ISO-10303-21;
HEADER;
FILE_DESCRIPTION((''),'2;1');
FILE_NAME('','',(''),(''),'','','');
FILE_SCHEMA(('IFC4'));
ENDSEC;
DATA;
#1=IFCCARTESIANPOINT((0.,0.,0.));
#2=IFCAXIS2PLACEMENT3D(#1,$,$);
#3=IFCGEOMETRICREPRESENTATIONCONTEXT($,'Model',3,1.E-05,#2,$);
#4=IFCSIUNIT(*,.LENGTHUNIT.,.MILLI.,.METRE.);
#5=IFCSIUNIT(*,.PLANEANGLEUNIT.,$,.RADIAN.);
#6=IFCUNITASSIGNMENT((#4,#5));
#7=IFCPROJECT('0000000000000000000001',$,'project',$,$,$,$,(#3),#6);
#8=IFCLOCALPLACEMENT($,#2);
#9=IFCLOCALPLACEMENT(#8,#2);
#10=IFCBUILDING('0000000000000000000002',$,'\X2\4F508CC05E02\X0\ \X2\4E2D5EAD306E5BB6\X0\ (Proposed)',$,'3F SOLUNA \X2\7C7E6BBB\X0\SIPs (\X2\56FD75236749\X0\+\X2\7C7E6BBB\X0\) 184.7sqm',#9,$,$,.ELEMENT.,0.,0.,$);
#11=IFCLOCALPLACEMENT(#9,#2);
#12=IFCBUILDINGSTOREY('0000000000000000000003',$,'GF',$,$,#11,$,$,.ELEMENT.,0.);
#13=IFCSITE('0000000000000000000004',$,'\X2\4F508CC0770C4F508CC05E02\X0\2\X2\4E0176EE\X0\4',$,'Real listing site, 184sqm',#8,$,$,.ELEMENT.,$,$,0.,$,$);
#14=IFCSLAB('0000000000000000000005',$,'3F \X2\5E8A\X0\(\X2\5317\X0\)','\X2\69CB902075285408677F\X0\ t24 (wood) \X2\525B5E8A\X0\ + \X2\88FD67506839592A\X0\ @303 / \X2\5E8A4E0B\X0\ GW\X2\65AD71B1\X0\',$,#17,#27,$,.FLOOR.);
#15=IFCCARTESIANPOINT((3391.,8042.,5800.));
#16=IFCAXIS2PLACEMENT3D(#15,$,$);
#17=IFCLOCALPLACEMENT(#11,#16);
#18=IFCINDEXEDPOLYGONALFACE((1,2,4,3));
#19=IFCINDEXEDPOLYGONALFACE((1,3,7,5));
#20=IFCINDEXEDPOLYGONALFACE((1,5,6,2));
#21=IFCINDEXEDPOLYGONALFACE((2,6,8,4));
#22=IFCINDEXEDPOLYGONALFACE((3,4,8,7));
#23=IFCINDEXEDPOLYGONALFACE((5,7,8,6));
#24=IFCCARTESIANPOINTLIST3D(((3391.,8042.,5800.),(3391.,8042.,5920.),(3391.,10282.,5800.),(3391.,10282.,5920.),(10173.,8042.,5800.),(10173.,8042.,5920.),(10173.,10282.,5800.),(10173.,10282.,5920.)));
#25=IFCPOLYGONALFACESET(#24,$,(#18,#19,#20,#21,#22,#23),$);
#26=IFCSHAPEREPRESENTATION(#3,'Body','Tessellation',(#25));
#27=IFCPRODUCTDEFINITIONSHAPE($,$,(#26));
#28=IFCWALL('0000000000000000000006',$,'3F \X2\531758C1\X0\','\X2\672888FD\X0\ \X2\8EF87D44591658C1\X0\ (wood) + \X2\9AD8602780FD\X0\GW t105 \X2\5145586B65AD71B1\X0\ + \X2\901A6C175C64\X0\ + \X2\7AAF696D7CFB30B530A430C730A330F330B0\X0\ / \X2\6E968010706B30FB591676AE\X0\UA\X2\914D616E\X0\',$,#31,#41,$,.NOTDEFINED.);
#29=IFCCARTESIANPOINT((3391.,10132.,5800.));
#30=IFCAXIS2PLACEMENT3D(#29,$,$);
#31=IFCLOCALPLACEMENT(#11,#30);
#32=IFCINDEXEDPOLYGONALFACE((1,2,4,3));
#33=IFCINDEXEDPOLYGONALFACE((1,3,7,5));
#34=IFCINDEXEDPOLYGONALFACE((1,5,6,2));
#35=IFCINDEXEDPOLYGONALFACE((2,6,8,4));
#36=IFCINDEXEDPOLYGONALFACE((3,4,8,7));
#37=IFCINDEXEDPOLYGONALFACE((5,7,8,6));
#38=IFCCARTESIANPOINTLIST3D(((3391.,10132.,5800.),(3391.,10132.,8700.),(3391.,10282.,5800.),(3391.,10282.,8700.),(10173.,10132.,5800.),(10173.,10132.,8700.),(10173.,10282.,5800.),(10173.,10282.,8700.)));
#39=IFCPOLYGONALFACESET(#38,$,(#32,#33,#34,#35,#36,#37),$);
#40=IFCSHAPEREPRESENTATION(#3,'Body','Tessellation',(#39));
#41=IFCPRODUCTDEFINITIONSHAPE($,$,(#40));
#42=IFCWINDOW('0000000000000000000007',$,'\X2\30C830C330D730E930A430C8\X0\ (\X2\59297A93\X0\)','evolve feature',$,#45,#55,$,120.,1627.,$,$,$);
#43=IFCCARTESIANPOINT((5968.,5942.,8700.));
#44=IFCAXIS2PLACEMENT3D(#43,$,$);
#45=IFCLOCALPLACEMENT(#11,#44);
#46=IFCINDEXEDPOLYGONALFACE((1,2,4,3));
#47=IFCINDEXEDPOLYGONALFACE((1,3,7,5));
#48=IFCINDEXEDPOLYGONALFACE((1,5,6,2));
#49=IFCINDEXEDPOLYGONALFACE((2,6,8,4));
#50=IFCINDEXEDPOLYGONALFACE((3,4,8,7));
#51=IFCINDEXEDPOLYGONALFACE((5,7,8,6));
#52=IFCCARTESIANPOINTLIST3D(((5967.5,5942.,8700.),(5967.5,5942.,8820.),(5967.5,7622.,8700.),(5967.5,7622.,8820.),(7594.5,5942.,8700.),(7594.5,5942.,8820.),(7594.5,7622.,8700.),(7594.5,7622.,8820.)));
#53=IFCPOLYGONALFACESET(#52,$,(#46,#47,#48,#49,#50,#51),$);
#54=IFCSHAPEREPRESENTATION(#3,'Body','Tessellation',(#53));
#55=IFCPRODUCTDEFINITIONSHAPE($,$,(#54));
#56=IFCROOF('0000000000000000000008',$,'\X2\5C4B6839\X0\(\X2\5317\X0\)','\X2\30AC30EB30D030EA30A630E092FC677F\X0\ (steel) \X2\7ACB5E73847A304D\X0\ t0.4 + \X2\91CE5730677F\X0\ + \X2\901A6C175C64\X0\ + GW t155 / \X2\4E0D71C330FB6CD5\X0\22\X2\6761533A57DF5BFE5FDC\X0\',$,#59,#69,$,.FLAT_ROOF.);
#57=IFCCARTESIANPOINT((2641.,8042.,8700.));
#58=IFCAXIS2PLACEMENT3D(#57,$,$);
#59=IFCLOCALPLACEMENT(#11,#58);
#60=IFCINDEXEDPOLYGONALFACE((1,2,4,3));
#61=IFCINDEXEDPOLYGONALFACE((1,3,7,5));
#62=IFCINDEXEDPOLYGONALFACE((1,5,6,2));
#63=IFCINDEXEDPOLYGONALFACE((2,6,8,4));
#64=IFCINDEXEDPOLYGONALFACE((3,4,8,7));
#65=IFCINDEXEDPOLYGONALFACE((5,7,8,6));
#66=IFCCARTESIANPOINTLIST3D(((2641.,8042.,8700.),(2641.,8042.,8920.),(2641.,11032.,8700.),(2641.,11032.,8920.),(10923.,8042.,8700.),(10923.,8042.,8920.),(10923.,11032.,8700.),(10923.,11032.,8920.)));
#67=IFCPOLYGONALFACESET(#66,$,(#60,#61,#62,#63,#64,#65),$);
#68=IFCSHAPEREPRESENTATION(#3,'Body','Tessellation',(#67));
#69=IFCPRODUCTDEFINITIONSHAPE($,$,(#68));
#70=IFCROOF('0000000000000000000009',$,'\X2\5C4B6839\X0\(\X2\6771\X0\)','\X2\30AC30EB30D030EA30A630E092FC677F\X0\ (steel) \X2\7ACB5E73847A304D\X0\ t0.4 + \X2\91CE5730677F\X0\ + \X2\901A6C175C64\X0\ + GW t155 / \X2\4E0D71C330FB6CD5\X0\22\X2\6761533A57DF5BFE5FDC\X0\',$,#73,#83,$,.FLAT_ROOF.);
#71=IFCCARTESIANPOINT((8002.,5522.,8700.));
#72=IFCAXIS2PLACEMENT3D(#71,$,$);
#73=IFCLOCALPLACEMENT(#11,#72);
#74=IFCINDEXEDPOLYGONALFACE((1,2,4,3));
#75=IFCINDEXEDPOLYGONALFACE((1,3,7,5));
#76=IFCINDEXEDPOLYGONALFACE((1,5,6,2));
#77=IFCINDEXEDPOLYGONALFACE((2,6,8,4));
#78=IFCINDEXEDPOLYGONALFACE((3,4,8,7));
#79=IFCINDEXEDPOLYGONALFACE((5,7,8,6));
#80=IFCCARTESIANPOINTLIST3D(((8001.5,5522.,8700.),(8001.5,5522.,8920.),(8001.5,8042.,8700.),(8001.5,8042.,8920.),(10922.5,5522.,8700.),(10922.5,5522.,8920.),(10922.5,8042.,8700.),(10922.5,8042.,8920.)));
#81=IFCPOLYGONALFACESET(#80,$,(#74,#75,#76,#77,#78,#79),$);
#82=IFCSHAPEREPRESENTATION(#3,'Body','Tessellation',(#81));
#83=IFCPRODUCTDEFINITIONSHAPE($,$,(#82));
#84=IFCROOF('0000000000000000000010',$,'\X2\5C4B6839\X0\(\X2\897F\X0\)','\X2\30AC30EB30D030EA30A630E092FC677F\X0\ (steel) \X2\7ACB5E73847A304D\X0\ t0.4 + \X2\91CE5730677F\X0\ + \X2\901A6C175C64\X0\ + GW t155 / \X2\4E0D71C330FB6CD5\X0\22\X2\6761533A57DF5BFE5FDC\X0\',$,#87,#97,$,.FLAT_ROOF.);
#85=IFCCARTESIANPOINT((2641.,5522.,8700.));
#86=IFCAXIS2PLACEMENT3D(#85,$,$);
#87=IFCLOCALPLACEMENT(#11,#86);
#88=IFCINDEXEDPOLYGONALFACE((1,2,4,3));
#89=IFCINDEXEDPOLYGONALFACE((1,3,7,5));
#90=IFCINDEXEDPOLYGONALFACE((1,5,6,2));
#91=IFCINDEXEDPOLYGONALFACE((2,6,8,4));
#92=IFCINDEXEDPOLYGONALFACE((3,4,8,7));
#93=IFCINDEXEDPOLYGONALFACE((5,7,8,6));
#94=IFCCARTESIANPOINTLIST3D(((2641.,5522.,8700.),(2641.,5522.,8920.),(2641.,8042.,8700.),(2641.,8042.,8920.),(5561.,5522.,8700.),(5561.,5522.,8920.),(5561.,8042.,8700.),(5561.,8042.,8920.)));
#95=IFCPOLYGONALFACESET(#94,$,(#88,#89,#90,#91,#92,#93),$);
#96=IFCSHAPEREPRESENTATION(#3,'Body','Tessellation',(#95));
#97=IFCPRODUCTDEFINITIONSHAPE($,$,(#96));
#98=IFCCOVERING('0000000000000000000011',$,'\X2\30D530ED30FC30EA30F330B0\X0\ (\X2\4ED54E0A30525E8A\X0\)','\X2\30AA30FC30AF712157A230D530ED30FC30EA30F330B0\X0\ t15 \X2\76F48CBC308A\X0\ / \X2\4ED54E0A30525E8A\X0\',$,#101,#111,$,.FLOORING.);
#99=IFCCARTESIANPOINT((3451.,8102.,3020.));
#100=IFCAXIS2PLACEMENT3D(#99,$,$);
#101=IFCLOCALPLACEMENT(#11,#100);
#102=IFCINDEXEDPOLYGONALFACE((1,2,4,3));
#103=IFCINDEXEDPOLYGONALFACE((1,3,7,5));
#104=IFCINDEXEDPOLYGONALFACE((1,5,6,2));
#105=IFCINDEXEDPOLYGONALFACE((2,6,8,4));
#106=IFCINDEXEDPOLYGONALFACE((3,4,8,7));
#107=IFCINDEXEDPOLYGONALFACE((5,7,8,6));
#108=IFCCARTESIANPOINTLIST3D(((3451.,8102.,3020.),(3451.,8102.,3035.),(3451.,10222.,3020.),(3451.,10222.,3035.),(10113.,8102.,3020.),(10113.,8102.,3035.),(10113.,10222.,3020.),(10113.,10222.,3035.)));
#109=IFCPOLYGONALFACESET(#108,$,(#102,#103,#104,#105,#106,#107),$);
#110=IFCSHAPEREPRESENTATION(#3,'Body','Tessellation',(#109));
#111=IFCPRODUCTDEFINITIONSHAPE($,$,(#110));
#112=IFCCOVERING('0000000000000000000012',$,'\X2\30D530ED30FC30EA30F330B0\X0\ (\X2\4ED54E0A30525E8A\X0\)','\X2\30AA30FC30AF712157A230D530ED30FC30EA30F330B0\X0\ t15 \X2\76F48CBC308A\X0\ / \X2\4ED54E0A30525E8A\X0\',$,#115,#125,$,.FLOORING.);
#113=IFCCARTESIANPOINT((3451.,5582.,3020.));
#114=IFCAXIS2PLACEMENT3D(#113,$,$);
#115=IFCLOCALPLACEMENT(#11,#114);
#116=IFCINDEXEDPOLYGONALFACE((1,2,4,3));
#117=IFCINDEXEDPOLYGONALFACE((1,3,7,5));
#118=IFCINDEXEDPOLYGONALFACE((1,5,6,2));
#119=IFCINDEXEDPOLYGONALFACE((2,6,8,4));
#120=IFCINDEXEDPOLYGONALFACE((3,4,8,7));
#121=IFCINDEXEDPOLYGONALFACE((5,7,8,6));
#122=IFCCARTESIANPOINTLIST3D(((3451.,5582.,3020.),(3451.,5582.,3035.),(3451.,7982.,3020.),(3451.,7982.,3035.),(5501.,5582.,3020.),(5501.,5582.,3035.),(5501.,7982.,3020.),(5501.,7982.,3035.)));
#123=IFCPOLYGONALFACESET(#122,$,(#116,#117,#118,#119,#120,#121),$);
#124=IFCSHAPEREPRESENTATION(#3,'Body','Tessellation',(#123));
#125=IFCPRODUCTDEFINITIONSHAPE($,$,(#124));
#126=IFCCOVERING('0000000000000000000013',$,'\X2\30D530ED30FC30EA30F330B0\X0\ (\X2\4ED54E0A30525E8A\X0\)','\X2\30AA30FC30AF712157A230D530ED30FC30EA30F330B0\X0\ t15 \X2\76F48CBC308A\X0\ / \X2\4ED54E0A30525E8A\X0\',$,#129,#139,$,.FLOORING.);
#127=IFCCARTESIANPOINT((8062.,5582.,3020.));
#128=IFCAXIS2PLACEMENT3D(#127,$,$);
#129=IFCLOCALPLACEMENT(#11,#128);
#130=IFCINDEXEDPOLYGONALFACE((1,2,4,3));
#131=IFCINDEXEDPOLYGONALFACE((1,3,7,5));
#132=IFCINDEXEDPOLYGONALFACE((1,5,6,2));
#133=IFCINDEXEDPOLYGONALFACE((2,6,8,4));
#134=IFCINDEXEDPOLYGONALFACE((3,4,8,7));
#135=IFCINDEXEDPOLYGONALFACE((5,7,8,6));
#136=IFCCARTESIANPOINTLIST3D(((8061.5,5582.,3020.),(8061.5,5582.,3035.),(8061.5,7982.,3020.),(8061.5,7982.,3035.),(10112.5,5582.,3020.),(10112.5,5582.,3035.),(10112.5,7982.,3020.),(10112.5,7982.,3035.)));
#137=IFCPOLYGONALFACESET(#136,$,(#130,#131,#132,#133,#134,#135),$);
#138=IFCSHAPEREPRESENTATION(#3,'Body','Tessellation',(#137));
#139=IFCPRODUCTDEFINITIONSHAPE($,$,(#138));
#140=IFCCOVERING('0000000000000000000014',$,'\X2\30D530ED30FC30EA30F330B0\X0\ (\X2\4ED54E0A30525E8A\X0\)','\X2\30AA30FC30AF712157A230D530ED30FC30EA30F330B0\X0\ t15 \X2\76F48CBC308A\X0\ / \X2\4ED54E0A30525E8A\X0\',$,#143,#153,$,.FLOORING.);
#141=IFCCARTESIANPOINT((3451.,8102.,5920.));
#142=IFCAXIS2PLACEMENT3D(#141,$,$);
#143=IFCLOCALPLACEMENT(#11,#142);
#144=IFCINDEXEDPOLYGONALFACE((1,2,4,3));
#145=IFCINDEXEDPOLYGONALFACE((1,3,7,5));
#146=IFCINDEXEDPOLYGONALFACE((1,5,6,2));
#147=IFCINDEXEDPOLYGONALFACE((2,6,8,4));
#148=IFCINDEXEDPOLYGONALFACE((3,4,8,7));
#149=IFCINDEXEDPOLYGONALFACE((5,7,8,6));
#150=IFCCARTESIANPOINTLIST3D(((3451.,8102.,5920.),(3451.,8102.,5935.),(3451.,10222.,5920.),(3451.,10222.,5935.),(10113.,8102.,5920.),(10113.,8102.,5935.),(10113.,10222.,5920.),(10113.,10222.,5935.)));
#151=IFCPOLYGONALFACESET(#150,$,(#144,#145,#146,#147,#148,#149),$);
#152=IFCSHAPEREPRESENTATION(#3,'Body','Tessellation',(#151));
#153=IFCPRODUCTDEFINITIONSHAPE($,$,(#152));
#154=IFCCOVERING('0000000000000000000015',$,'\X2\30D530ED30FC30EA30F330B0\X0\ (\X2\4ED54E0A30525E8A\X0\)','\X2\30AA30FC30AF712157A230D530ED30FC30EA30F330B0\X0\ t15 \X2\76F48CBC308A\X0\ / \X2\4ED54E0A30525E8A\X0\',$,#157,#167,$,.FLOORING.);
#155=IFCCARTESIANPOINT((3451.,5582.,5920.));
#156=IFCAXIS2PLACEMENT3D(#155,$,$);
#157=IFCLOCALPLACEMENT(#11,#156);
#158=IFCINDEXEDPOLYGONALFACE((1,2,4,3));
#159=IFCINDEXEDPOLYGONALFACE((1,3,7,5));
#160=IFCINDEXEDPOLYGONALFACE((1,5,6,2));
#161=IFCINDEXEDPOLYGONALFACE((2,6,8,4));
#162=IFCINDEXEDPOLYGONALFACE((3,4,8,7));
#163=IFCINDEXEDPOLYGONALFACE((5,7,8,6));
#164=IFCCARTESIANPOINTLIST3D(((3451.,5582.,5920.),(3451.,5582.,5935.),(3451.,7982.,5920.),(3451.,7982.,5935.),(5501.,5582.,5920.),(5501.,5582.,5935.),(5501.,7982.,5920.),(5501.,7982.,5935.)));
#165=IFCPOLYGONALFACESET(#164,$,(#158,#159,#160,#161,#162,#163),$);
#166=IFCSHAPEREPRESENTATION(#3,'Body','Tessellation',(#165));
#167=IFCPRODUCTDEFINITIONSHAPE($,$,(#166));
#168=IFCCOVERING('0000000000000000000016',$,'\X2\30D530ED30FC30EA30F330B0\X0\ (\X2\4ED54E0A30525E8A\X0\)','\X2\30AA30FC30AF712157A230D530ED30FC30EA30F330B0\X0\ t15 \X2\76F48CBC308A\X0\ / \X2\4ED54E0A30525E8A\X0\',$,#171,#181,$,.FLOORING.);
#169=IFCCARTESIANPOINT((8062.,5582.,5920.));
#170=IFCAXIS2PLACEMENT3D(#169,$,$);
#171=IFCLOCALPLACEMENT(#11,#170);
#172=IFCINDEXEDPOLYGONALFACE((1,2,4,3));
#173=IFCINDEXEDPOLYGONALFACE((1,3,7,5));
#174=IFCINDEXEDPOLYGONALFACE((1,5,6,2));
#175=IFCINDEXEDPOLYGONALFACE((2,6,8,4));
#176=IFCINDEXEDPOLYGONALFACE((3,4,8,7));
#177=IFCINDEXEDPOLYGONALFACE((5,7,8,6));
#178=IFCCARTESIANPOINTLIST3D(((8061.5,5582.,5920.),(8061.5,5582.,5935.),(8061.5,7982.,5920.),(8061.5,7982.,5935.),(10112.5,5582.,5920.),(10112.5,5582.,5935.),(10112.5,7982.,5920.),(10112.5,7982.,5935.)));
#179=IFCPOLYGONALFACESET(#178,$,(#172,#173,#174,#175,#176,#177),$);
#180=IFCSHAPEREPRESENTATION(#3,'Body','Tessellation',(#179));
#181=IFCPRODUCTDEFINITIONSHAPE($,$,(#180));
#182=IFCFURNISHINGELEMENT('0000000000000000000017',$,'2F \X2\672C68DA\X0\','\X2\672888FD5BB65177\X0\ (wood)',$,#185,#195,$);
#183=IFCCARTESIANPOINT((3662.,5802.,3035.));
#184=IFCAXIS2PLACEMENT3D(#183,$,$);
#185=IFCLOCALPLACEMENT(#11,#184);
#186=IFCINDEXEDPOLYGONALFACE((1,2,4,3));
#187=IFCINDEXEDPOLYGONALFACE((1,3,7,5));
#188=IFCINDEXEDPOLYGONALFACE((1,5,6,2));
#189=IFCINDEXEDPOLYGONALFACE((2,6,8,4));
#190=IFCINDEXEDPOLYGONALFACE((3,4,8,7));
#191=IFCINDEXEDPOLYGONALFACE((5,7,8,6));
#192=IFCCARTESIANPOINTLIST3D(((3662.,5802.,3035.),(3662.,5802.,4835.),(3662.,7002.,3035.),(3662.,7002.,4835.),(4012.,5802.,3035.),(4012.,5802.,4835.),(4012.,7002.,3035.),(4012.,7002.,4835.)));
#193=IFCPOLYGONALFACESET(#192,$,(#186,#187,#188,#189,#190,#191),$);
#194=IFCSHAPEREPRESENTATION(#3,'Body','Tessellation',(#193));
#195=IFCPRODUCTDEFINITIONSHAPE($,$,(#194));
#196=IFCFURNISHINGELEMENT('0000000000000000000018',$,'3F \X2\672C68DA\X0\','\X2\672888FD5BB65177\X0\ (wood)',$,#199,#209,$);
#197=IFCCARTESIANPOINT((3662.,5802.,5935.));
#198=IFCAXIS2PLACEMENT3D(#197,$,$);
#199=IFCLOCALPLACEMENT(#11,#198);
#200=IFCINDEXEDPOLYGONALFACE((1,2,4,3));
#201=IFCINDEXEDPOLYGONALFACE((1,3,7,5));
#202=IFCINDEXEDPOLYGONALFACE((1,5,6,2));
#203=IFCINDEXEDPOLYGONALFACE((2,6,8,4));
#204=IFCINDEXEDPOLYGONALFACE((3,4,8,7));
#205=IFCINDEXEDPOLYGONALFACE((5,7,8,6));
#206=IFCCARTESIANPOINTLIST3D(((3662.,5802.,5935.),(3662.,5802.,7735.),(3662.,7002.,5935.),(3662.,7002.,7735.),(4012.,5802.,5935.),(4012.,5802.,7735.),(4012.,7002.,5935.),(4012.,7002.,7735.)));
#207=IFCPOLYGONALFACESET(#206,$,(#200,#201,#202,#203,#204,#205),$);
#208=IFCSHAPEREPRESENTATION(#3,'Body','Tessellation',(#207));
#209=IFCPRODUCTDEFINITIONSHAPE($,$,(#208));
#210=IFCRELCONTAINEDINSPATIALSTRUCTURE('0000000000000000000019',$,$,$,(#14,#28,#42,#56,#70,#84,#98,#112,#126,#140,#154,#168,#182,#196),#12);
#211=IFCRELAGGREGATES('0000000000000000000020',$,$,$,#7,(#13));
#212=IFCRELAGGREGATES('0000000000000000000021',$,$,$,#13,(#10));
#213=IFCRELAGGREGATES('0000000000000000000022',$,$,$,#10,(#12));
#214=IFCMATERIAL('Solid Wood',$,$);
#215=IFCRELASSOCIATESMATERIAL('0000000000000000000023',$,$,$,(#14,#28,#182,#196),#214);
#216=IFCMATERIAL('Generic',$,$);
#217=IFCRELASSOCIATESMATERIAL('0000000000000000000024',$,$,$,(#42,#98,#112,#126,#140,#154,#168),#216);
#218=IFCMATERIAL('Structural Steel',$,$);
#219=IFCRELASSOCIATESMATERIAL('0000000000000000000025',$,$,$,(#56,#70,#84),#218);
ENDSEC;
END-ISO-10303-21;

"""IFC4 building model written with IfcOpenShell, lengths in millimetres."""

from ifc_helpers import new_model, si_unit, frame, frame_2d, origin, place, context, project, spatial, rectangle, extrude, material, element, save


model = new_model("IFC4")

# Units and contexts
model_context = context("Model", 3, precision=1e-05, world=origin())
ifc_project = project(units=[si_unit("LENGTHUNIT", "METRE", prefix="MILLI"), si_unit("PLANEANGLEUNIT", "RADIAN")], contexts=[model_context])

# Site, building, storey
site_placement = place(None, origin())
site = spatial("IfcSite", under=ifc_project, at=site_placement, Name="佐賀県佐賀市2丁目4", ObjectType="Real listing site, 184sqm", CompositionType="ELEMENT", RefElevation=0.0)
building_placement = place(site_placement, origin())
building = spatial("IfcBuilding", under=site, at=building_placement, Name="佐賀市 中庭の家 (Proposed)", ObjectType="3F SOLUNA 籾殻SIPs (国産杉+籾殻) 184.7sqm", CompositionType="ELEMENT", ElevationOfRefHeight=0.0, ElevationOfTerrain=0.0)
storey_placement = place(building_placement, origin())
storey = spatial("IfcBuildingStorey", under=building, at=storey_placement, Name="GF", CompositionType="ELEMENT", Elevation=0.0)

# Slab
ifc_material_1 = material(Name="Solid Wood")
slab_placement = place(storey_placement, frame((3391.0, 8042.0, 5800.0)))
element("IfcSlab", 1, at=slab_placement, inside=storey, material=ifc_material_1, Name="3F 床(北)", Description="構造用合板 t24 (wood) 剛床 + 製材根太 @303 / 床下 GW断熱", PredefinedType="FLOOR", context=model_context, shape_type="SweptSolid", body=[
    extrude(rectangle(XDim=6782.0, YDim=2240.0, at=frame_2d((3391.0, 1120.0))), frame((3391.0, 8042.0, 5800.0)), (0.0, 0.0, 1.0), 120.0),
])

# Wall
wall_1_placement = place(storey_placement, frame((3391.0, 10132.0, 5800.0)))
element("IfcWall", 2, at=wall_1_placement, inside=storey, material=ifc_material_1, Name="3F 北壁", Description="木製 軸組外壁 (wood) + 高性能GW t105 充填断熱 + 通気層 + 窯業系サイディング / 準耐火・外皮UA配慮", PredefinedType="NOTDEFINED", context=model_context, shape_type="SweptSolid", body=[
    extrude(rectangle(XDim=6782.0, YDim=150.0, at=frame_2d((3391.0, 75.0))), frame((3391.0, 10132.0, 5800.0)), (0.0, 0.0, 1.0), 2900.0),
])

# Window
ifc_material_2 = material(Name="Generic")
window_1_placement = place(storey_placement, frame((5968.0, 5942.0, 8700.0)))
element("IfcWindow", 3, at=window_1_placement, inside=storey, material=ifc_material_2, Name="トップライト (天窓)", Description="evolve feature", OverallHeight=120.0, OverallWidth=1627.0, context=model_context, shape_type="SweptSolid", body=[
    extrude(rectangle(XDim=1627.0, YDim=1680.0, at=frame_2d((813.0, 840.0))), frame((5968.0, 5942.0, 8700.0)), (0.0, 0.0, 1.0), 120.0),
])

# Roofs
ifc_material_3 = material(Name="Structural Steel")
roof_1_placement = place(storey_placement, frame((2641.0, 8042.0, 8700.0)))
element("IfcRoof", 4, at=roof_1_placement, inside=storey, material=ifc_material_3, Name="屋根(北)", Description="ガルバリウム鋼板 (steel) 立平葺き t0.4 + 野地板 + 通気層 + GW t155 / 不燃・法22条区域対応", PredefinedType="FLAT_ROOF", context=model_context, shape_type="SweptSolid", body=[
    extrude(rectangle(XDim=8282.0, YDim=2990.0, at=frame_2d((4141.0, 1495.0))), frame((2641.0, 8042.0, 8700.0)), (0.0, 0.0, 1.0), 220.0),
])
roof_2_placement = place(storey_placement, frame((8002.0, 5522.0, 8700.0)))
element("IfcRoof", 5, at=roof_2_placement, inside=storey, material=ifc_material_3, Name="屋根(東)", Description="ガルバリウム鋼板 (steel) 立平葺き t0.4 + 野地板 + 通気層 + GW t155 / 不燃・法22条区域対応", PredefinedType="FLAT_ROOF", context=model_context, shape_type="SweptSolid", body=[
    extrude(rectangle(XDim=2921.0, YDim=2520.0, at=frame_2d((1460.0, 1260.0))), frame((8002.0, 5522.0, 8700.0)), (0.0, 0.0, 1.0), 220.0),
])
roof_3_placement = place(storey_placement, frame((2641.0, 5522.0, 8700.0)))
element("IfcRoof", 6, at=roof_3_placement, inside=storey, material=ifc_material_3, Name="屋根(西)", Description="ガルバリウム鋼板 (steel) 立平葺き t0.4 + 野地板 + 通気層 + GW t155 / 不燃・法22条区域対応", PredefinedType="FLAT_ROOF", context=model_context, shape_type="SweptSolid", body=[
    extrude(rectangle(XDim=2920.0, YDim=2520.0, at=frame_2d((1460.0, 1260.0))), frame((2641.0, 5522.0, 8700.0)), (0.0, 0.0, 1.0), 220.0),
])

# Coverings
covering_1_placement = place(storey_placement, frame((3451.0, 8102.0, 3020.0)))
element("IfcCovering", 7, at=covering_1_placement, inside=storey, material=ifc_material_2, Name="フローリング (仕上げ床)", Description="オーク無垢フローリング t15 直貼り / 仕上げ床", PredefinedType="FLOORING", context=model_context, shape_type="SweptSolid", body=[
    extrude(rectangle(XDim=6662.0, YDim=2120.0, at=frame_2d((3331.0, 1060.0))), frame((3451.0, 8102.0, 3020.0)), (0.0, 0.0, 1.0), 15.0),
])
covering_2_placement = place(storey_placement, frame((3451.0, 5582.0, 3020.0)))
element("IfcCovering", 8, at=covering_2_placement, inside=storey, material=ifc_material_2, Name="フローリング (仕上げ床)", Description="オーク無垢フローリング t15 直貼り / 仕上げ床", PredefinedType="FLOORING", context=model_context, shape_type="SweptSolid", body=[
    extrude(rectangle(XDim=2050.0, YDim=2400.0, at=frame_2d((1025.0, 1200.0))), frame((3451.0, 5582.0, 3020.0)), (0.0, 0.0, 1.0), 15.0),
])
covering_3_placement = place(storey_placement, frame((8062.0, 5582.0, 3020.0)))
element("IfcCovering", 9, at=covering_3_placement, inside=storey, material=ifc_material_2, Name="フローリング (仕上げ床)", Description="オーク無垢フローリング t15 直貼り / 仕上げ床", PredefinedType="FLOORING", context=model_context, shape_type="SweptSolid", body=[
    extrude(rectangle(XDim=2051.0, YDim=2400.0, at=frame_2d((1025.0, 1200.0))), frame((8062.0, 5582.0, 3020.0)), (0.0, 0.0, 1.0), 15.0),
])
covering_4_placement = place(storey_placement, frame((3451.0, 8102.0, 5920.0)))
element("IfcCovering", 10, at=covering_4_placement, inside=storey, material=ifc_material_2, Name="フローリング (仕上げ床)", Description="オーク無垢フローリング t15 直貼り / 仕上げ床", PredefinedType="FLOORING", context=model_context, shape_type="SweptSolid", body=[
    extrude(rectangle(XDim=6662.0, YDim=2120.0, at=frame_2d((3331.0, 1060.0))), frame((3451.0, 8102.0, 5920.0)), (0.0, 0.0, 1.0), 15.0),
])
covering_5_placement = place(storey_placement, frame((3451.0, 5582.0, 5920.0)))
element("IfcCovering", 11, at=covering_5_placement, inside=storey, material=ifc_material_2, Name="フローリング (仕上げ床)", Description="オーク無垢フローリング t15 直貼り / 仕上げ床", PredefinedType="FLOORING", context=model_context, shape_type="SweptSolid", body=[
    extrude(rectangle(XDim=2050.0, YDim=2400.0, at=frame_2d((1025.0, 1200.0))), frame((3451.0, 5582.0, 5920.0)), (0.0, 0.0, 1.0), 15.0),
])
covering_6_placement = place(storey_placement, frame((8062.0, 5582.0, 5920.0)))
element("IfcCovering", 12, at=covering_6_placement, inside=storey, material=ifc_material_2, Name="フローリング (仕上げ床)", Description="オーク無垢フローリング t15 直貼り / 仕上げ床", PredefinedType="FLOORING", context=model_context, shape_type="SweptSolid", body=[
    extrude(rectangle(XDim=2051.0, YDim=2400.0, at=frame_2d((1025.0, 1200.0))), frame((8062.0, 5582.0, 5920.0)), (0.0, 0.0, 1.0), 15.0),
])

# Furnishing elements
furnishing_1_placement = place(storey_placement, frame((3662.0, 5802.0, 3035.0)))
element("IfcFurnishingElement", 13, at=furnishing_1_placement, inside=storey, material=ifc_material_1, Name="2F 本棚", Description="木製家具 (wood)", context=model_context, shape_type="SweptSolid", body=[
    extrude(rectangle(XDim=350.0, YDim=1200.0, at=frame_2d((175.0, 600.0))), frame((3662.0, 5802.0, 3035.0)), (0.0, 0.0, 1.0), 1800.0),
])
furnishing_2_placement = place(storey_placement, frame((3662.0, 5802.0, 5935.0)))
element("IfcFurnishingElement", 14, at=furnishing_2_placement, inside=storey, material=ifc_material_1, Name="3F 本棚", Description="木製家具 (wood)", context=model_context, shape_type="SweptSolid", body=[
    extrude(rectangle(XDim=350.0, YDim=1200.0, at=frame_2d((175.0, 600.0))), frame((3662.0, 5802.0, 5935.0)), (0.0, 0.0, 1.0), 1800.0),
])

save(model, "model.ifc")
